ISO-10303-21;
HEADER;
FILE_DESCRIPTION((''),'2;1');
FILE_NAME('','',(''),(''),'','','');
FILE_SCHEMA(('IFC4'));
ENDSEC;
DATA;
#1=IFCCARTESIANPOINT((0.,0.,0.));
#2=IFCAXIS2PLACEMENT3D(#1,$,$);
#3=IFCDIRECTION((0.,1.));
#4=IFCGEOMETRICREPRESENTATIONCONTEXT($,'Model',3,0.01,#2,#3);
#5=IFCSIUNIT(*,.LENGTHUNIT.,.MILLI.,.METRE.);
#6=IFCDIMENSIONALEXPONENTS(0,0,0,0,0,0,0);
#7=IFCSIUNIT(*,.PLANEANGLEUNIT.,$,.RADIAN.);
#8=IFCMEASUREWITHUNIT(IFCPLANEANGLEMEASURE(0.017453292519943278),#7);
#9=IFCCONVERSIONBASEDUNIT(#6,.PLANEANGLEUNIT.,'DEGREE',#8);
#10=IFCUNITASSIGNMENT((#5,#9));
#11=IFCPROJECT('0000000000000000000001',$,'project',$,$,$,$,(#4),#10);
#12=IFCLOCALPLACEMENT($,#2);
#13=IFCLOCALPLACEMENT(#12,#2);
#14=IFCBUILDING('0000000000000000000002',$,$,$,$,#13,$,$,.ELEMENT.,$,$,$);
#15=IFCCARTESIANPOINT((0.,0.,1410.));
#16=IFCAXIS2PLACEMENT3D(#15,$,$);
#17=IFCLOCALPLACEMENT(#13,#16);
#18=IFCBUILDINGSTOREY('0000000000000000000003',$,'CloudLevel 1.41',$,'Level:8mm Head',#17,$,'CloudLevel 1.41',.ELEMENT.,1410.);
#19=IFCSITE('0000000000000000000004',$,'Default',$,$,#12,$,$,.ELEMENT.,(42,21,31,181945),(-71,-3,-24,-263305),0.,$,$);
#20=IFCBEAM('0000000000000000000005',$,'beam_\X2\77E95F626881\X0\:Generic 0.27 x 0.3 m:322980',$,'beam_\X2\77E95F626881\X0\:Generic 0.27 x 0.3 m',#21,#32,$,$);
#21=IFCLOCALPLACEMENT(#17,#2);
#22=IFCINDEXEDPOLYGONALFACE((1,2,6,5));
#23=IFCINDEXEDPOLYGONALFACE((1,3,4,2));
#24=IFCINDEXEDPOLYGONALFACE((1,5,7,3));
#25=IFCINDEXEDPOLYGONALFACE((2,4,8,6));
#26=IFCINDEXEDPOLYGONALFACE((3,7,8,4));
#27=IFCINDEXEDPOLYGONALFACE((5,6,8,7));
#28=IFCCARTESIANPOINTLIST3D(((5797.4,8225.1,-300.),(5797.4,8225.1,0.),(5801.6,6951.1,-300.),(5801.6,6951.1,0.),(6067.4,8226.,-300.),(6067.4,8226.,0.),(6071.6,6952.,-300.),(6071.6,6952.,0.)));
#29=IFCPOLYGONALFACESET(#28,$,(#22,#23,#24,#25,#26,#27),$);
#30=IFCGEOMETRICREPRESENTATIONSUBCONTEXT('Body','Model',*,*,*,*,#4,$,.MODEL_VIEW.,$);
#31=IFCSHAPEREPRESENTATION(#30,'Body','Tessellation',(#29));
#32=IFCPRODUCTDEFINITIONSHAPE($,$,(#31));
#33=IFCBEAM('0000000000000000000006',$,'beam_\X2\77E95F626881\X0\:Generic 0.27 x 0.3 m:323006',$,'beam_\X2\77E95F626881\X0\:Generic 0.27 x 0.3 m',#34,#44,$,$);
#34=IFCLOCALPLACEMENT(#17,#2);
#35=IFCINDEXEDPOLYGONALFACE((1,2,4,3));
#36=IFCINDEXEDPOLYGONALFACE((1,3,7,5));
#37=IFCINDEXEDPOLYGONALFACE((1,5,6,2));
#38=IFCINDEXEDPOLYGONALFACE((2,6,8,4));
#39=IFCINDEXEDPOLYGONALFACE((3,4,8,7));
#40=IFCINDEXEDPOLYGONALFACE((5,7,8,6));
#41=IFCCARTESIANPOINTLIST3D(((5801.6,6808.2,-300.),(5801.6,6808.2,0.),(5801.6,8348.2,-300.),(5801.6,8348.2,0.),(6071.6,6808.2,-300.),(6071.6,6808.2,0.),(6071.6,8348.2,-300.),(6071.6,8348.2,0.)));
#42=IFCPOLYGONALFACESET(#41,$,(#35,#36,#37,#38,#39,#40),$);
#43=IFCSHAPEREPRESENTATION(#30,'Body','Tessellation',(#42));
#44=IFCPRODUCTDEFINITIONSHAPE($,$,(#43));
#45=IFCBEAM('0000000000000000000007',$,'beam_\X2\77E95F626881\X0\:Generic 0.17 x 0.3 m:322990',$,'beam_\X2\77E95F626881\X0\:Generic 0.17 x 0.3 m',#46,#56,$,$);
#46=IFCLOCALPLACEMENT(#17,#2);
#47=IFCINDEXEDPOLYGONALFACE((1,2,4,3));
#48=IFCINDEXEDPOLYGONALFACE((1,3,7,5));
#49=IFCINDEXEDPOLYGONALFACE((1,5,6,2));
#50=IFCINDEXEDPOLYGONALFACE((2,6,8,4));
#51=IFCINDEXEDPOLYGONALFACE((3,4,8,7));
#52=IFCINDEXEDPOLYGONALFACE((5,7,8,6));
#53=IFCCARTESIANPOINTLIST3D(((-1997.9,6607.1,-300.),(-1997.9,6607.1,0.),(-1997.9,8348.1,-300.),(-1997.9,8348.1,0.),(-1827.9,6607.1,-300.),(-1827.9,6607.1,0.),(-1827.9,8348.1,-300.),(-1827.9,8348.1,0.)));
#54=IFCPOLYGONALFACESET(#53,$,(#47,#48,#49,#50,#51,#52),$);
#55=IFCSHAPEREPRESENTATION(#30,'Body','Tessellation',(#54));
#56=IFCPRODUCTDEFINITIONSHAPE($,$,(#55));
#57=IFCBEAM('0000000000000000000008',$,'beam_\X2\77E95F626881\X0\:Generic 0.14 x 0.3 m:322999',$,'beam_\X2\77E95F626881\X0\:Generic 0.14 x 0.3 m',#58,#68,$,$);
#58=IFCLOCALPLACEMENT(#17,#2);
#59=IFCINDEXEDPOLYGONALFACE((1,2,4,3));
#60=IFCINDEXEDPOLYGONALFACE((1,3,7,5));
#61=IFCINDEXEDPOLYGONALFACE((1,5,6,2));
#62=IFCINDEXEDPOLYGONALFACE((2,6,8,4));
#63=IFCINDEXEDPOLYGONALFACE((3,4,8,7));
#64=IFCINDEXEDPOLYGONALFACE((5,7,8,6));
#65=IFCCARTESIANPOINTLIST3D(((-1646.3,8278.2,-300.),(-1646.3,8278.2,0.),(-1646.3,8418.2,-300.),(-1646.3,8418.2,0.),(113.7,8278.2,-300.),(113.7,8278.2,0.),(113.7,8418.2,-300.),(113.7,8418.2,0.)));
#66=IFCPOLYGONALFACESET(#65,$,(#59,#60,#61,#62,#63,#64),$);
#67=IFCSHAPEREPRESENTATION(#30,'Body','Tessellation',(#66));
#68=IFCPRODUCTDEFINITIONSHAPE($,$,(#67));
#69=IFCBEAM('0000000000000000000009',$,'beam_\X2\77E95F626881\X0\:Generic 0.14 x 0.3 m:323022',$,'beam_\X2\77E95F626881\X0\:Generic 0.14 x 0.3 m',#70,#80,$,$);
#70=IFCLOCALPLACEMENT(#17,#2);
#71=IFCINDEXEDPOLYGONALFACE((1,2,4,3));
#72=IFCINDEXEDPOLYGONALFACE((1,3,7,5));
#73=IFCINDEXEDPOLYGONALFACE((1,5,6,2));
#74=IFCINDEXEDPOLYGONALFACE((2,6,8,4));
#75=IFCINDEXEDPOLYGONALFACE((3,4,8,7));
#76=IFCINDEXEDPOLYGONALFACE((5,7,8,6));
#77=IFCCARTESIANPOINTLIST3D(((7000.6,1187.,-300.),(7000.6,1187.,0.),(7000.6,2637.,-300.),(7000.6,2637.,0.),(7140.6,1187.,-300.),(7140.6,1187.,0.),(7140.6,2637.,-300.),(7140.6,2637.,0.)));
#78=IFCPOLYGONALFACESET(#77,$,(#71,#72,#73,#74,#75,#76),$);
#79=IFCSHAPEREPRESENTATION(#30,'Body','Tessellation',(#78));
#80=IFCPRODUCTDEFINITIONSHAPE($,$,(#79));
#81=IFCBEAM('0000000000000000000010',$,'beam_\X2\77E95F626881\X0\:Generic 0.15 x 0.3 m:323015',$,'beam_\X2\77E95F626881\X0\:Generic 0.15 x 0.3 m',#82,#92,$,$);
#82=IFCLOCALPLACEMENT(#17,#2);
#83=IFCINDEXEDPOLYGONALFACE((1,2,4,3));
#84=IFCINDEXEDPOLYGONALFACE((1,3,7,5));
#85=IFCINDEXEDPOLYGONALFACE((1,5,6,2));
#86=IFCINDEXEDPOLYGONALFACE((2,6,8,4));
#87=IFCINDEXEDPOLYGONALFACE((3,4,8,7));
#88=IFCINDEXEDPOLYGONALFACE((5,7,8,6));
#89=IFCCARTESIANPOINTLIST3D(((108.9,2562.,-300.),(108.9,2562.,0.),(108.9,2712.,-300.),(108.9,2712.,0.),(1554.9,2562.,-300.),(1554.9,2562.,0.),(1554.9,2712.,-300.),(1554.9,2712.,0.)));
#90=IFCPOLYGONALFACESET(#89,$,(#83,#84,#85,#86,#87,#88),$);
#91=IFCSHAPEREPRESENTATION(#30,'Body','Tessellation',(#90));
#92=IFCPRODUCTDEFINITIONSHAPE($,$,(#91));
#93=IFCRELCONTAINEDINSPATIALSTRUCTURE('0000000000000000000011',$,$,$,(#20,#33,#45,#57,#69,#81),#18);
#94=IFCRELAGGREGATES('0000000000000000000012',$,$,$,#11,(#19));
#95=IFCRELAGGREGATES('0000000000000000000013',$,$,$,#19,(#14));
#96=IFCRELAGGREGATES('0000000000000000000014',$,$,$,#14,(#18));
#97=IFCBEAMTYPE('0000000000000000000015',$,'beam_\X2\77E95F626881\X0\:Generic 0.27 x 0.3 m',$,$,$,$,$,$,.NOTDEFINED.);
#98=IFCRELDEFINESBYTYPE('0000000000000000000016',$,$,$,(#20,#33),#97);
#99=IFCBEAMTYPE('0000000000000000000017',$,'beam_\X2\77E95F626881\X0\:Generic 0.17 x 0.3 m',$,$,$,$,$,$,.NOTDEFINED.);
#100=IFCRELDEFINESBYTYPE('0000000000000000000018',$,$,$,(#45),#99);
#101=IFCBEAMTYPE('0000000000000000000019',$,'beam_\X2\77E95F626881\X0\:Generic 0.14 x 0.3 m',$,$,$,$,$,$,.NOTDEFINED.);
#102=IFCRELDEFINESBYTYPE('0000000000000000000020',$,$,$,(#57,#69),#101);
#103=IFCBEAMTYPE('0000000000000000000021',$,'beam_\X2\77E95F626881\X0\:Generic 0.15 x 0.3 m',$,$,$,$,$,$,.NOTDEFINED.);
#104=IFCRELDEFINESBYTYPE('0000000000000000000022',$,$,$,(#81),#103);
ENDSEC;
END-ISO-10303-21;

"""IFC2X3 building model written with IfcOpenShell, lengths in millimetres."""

from ifc_helpers import new_model, entity, si_unit, converted_unit, direction, frame, frame_2d, origin, place, context, subcontext, project, spatial, rectangle, extrude, type_object, element, save


model = new_model("IFC2X3")

# Units and contexts
model_context = context("Model", 3, precision=0.01, world=origin(), true_north=direction((0.0, 1.0)))
body_context = subcontext(model_context, "Body", "Model", "MODEL_VIEW")
ifc_project = project(units=[si_unit("LENGTHUNIT", "METRE", prefix="MILLI"), converted_unit("PLANEANGLEUNIT", "DEGREE", entity("IfcPlaneAngleMeasure", 0.017453292519943278), si_unit("PLANEANGLEUNIT", "RADIAN"), dimensions=[0, 0, 0, 0, 0, 0, 0])], contexts=[model_context])

# Site, building, storey
site_placement = place(None, origin())
site = spatial("IfcSite", under=ifc_project, at=site_placement, Name="Default", CompositionType="ELEMENT", RefLatitude=(42, 21, 31, 181945), RefLongitude=(-71, -3, -24, -263305), RefElevation=0.0)
building_placement = place(site_placement, origin())
building = spatial("IfcBuilding", under=site, at=building_placement, CompositionType="ELEMENT")
storey_placement = place(building_placement, frame((0.0, 0.0, 1410.0)))
storey = spatial("IfcBuildingStorey", under=building, at=storey_placement, Name="CloudLevel 1.41", ObjectType="Level:8mm Head", LongName="CloudLevel 1.41", CompositionType="ELEMENT", Elevation=1410.0)

# Beams
beam_type_1 = type_object("IfcBeamType", Name="beam_矩形梁:Generic 0.27 x 0.3 m", PredefinedType="NOTDEFINED")
beam_1_placement = place(storey_placement, frame((5932.4, 8225.9, 0.0), z_axis=(0.0, 0.0, 1.0), x_axis=(0.00334, -0.999994, 0.0)))
element("IfcBeam", 1, at=beam_1_placement, inside=storey, type_object=beam_type_1, Name="beam_矩形梁:Generic 0.27 x 0.3 m:322980", ObjectType="beam_矩形梁:Generic 0.27 x 0.3 m", context=body_context, shape_type="SweptSolid", body=[
    extrude(rectangle(XDim=300.0, YDim=270.0, at=frame_2d((0.0, 0.0), x_axis=(1.0, 0.0))), frame((0.3, 0.0, -150.0), z_axis=(1.0, 0.0, 0.0), x_axis=(0.0, 0.0, -1.0)), (0.0, 0.0, 1.0), 1274.0),
])
beam_2_placement = place(storey_placement, frame((5936.6, 8348.2, 0.0), z_axis=(0.0, 0.0, 1.0), x_axis=(0.0, -1.0, 0.0)))
element("IfcBeam", 2, at=beam_2_placement, inside=storey, type_object=beam_type_1, Name="beam_矩形梁:Generic 0.27 x 0.3 m:323006", ObjectType="beam_矩形梁:Generic 0.27 x 0.3 m", context=body_context, shape_type="SweptSolid", body=[
    extrude(rectangle(XDim=300.0, YDim=270.0, at=frame_2d((0.0, 0.0), x_axis=(1.0, 0.0))), frame((0.0, 0.0, -150.0), z_axis=(1.0, 0.0, 0.0), x_axis=(0.0, 0.0, -1.0)), (0.0, 0.0, 1.0), 1540.0),
])
beam_type_2 = type_object("IfcBeamType", Name="beam_矩形梁:Generic 0.17 x 0.3 m", PredefinedType="NOTDEFINED")
beam_3_placement = place(storey_placement, frame((-1912.9, 8348.2, 0.0), z_axis=(0.0, 0.0, 1.0), x_axis=(0.0, -1.0, 0.0)))
element("IfcBeam", 3, at=beam_3_placement, inside=storey, type_object=beam_type_2, Name="beam_矩形梁:Generic 0.17 x 0.3 m:322990", ObjectType="beam_矩形梁:Generic 0.17 x 0.3 m", context=body_context, shape_type="SweptSolid", body=[
    extrude(rectangle(XDim=300.0, YDim=170.0, at=frame_2d((0.0, 0.0), x_axis=(1.0, 0.0))), frame((0.1, 0.0, -150.0), z_axis=(1.0, 0.0, 0.0), x_axis=(0.0, 0.0, -1.0)), (0.0, 0.0, 1.0), 1741.0),
])
beam_type_3 = type_object("IfcBeamType", Name="beam_矩形梁:Generic 0.14 x 0.3 m", PredefinedType="NOTDEFINED")
beam_4_placement = place(storey_placement, frame((-1646.3, 8348.2, 0.0)))
element("IfcBeam", 4, at=beam_4_placement, inside=storey, type_object=beam_type_3, Name="beam_矩形梁:Generic 0.14 x 0.3 m:322999", ObjectType="beam_矩形梁:Generic 0.14 x 0.3 m", context=body_context, shape_type="SweptSolid", body=[
    extrude(rectangle(XDim=300.0, YDim=140.0, at=frame_2d((0.0, 0.0), x_axis=(1.0, 0.0))), frame((0.0, 0.0, -150.0), z_axis=(1.0, 0.0, 0.0), x_axis=(0.0, 0.0, -1.0)), (0.0, 0.0, 1.0), 1760.0),
])
beam_5_placement = place(storey_placement, frame((7070.6, 2637.0, 0.0), z_axis=(0.0, 0.0, 1.0), x_axis=(0.0, -1.0, 0.0)))
element("IfcBeam", 5, at=beam_5_placement, inside=storey, type_object=beam_type_3, Name="beam_矩形梁:Generic 0.14 x 0.3 m:323022", ObjectType="beam_矩形梁:Generic 0.14 x 0.3 m", context=body_context, shape_type="SweptSolid", body=[
    extrude(rectangle(XDim=300.0, YDim=140.0, at=frame_2d((0.0, 0.0), x_axis=(1.0, 0.0))), frame((0.0, 0.0, -150.0), z_axis=(1.0, 0.0, 0.0), x_axis=(0.0, 0.0, -1.0)), (0.0, 0.0, 1.0), 1450.0),
])
beam_type_4 = type_object("IfcBeamType", Name="beam_矩形梁:Generic 0.15 x 0.3 m", PredefinedType="NOTDEFINED")
beam_6_placement = place(storey_placement, frame((1554.9, 2637.0, 0.0), z_axis=(0.0, 0.0, 1.0), x_axis=(-1.0, 0.0, 0.0)))
element("IfcBeam", 6, at=beam_6_placement, inside=storey, type_object=beam_type_4, Name="beam_矩形梁:Generic 0.15 x 0.3 m:323015", ObjectType="beam_矩形梁:Generic 0.15 x 0.3 m", context=body_context, shape_type="SweptSolid", body=[
    extrude(rectangle(XDim=300.0, YDim=150.0, at=frame_2d((0.0, 0.0), x_axis=(1.0, 0.0))), frame((0.0, 0.0, -150.0), z_axis=(1.0, 0.0, 0.0), x_axis=(0.0, 0.0, -1.0)), (0.0, 0.0, 1.0), 1446.0),
])

save(model, "model.ifc")
